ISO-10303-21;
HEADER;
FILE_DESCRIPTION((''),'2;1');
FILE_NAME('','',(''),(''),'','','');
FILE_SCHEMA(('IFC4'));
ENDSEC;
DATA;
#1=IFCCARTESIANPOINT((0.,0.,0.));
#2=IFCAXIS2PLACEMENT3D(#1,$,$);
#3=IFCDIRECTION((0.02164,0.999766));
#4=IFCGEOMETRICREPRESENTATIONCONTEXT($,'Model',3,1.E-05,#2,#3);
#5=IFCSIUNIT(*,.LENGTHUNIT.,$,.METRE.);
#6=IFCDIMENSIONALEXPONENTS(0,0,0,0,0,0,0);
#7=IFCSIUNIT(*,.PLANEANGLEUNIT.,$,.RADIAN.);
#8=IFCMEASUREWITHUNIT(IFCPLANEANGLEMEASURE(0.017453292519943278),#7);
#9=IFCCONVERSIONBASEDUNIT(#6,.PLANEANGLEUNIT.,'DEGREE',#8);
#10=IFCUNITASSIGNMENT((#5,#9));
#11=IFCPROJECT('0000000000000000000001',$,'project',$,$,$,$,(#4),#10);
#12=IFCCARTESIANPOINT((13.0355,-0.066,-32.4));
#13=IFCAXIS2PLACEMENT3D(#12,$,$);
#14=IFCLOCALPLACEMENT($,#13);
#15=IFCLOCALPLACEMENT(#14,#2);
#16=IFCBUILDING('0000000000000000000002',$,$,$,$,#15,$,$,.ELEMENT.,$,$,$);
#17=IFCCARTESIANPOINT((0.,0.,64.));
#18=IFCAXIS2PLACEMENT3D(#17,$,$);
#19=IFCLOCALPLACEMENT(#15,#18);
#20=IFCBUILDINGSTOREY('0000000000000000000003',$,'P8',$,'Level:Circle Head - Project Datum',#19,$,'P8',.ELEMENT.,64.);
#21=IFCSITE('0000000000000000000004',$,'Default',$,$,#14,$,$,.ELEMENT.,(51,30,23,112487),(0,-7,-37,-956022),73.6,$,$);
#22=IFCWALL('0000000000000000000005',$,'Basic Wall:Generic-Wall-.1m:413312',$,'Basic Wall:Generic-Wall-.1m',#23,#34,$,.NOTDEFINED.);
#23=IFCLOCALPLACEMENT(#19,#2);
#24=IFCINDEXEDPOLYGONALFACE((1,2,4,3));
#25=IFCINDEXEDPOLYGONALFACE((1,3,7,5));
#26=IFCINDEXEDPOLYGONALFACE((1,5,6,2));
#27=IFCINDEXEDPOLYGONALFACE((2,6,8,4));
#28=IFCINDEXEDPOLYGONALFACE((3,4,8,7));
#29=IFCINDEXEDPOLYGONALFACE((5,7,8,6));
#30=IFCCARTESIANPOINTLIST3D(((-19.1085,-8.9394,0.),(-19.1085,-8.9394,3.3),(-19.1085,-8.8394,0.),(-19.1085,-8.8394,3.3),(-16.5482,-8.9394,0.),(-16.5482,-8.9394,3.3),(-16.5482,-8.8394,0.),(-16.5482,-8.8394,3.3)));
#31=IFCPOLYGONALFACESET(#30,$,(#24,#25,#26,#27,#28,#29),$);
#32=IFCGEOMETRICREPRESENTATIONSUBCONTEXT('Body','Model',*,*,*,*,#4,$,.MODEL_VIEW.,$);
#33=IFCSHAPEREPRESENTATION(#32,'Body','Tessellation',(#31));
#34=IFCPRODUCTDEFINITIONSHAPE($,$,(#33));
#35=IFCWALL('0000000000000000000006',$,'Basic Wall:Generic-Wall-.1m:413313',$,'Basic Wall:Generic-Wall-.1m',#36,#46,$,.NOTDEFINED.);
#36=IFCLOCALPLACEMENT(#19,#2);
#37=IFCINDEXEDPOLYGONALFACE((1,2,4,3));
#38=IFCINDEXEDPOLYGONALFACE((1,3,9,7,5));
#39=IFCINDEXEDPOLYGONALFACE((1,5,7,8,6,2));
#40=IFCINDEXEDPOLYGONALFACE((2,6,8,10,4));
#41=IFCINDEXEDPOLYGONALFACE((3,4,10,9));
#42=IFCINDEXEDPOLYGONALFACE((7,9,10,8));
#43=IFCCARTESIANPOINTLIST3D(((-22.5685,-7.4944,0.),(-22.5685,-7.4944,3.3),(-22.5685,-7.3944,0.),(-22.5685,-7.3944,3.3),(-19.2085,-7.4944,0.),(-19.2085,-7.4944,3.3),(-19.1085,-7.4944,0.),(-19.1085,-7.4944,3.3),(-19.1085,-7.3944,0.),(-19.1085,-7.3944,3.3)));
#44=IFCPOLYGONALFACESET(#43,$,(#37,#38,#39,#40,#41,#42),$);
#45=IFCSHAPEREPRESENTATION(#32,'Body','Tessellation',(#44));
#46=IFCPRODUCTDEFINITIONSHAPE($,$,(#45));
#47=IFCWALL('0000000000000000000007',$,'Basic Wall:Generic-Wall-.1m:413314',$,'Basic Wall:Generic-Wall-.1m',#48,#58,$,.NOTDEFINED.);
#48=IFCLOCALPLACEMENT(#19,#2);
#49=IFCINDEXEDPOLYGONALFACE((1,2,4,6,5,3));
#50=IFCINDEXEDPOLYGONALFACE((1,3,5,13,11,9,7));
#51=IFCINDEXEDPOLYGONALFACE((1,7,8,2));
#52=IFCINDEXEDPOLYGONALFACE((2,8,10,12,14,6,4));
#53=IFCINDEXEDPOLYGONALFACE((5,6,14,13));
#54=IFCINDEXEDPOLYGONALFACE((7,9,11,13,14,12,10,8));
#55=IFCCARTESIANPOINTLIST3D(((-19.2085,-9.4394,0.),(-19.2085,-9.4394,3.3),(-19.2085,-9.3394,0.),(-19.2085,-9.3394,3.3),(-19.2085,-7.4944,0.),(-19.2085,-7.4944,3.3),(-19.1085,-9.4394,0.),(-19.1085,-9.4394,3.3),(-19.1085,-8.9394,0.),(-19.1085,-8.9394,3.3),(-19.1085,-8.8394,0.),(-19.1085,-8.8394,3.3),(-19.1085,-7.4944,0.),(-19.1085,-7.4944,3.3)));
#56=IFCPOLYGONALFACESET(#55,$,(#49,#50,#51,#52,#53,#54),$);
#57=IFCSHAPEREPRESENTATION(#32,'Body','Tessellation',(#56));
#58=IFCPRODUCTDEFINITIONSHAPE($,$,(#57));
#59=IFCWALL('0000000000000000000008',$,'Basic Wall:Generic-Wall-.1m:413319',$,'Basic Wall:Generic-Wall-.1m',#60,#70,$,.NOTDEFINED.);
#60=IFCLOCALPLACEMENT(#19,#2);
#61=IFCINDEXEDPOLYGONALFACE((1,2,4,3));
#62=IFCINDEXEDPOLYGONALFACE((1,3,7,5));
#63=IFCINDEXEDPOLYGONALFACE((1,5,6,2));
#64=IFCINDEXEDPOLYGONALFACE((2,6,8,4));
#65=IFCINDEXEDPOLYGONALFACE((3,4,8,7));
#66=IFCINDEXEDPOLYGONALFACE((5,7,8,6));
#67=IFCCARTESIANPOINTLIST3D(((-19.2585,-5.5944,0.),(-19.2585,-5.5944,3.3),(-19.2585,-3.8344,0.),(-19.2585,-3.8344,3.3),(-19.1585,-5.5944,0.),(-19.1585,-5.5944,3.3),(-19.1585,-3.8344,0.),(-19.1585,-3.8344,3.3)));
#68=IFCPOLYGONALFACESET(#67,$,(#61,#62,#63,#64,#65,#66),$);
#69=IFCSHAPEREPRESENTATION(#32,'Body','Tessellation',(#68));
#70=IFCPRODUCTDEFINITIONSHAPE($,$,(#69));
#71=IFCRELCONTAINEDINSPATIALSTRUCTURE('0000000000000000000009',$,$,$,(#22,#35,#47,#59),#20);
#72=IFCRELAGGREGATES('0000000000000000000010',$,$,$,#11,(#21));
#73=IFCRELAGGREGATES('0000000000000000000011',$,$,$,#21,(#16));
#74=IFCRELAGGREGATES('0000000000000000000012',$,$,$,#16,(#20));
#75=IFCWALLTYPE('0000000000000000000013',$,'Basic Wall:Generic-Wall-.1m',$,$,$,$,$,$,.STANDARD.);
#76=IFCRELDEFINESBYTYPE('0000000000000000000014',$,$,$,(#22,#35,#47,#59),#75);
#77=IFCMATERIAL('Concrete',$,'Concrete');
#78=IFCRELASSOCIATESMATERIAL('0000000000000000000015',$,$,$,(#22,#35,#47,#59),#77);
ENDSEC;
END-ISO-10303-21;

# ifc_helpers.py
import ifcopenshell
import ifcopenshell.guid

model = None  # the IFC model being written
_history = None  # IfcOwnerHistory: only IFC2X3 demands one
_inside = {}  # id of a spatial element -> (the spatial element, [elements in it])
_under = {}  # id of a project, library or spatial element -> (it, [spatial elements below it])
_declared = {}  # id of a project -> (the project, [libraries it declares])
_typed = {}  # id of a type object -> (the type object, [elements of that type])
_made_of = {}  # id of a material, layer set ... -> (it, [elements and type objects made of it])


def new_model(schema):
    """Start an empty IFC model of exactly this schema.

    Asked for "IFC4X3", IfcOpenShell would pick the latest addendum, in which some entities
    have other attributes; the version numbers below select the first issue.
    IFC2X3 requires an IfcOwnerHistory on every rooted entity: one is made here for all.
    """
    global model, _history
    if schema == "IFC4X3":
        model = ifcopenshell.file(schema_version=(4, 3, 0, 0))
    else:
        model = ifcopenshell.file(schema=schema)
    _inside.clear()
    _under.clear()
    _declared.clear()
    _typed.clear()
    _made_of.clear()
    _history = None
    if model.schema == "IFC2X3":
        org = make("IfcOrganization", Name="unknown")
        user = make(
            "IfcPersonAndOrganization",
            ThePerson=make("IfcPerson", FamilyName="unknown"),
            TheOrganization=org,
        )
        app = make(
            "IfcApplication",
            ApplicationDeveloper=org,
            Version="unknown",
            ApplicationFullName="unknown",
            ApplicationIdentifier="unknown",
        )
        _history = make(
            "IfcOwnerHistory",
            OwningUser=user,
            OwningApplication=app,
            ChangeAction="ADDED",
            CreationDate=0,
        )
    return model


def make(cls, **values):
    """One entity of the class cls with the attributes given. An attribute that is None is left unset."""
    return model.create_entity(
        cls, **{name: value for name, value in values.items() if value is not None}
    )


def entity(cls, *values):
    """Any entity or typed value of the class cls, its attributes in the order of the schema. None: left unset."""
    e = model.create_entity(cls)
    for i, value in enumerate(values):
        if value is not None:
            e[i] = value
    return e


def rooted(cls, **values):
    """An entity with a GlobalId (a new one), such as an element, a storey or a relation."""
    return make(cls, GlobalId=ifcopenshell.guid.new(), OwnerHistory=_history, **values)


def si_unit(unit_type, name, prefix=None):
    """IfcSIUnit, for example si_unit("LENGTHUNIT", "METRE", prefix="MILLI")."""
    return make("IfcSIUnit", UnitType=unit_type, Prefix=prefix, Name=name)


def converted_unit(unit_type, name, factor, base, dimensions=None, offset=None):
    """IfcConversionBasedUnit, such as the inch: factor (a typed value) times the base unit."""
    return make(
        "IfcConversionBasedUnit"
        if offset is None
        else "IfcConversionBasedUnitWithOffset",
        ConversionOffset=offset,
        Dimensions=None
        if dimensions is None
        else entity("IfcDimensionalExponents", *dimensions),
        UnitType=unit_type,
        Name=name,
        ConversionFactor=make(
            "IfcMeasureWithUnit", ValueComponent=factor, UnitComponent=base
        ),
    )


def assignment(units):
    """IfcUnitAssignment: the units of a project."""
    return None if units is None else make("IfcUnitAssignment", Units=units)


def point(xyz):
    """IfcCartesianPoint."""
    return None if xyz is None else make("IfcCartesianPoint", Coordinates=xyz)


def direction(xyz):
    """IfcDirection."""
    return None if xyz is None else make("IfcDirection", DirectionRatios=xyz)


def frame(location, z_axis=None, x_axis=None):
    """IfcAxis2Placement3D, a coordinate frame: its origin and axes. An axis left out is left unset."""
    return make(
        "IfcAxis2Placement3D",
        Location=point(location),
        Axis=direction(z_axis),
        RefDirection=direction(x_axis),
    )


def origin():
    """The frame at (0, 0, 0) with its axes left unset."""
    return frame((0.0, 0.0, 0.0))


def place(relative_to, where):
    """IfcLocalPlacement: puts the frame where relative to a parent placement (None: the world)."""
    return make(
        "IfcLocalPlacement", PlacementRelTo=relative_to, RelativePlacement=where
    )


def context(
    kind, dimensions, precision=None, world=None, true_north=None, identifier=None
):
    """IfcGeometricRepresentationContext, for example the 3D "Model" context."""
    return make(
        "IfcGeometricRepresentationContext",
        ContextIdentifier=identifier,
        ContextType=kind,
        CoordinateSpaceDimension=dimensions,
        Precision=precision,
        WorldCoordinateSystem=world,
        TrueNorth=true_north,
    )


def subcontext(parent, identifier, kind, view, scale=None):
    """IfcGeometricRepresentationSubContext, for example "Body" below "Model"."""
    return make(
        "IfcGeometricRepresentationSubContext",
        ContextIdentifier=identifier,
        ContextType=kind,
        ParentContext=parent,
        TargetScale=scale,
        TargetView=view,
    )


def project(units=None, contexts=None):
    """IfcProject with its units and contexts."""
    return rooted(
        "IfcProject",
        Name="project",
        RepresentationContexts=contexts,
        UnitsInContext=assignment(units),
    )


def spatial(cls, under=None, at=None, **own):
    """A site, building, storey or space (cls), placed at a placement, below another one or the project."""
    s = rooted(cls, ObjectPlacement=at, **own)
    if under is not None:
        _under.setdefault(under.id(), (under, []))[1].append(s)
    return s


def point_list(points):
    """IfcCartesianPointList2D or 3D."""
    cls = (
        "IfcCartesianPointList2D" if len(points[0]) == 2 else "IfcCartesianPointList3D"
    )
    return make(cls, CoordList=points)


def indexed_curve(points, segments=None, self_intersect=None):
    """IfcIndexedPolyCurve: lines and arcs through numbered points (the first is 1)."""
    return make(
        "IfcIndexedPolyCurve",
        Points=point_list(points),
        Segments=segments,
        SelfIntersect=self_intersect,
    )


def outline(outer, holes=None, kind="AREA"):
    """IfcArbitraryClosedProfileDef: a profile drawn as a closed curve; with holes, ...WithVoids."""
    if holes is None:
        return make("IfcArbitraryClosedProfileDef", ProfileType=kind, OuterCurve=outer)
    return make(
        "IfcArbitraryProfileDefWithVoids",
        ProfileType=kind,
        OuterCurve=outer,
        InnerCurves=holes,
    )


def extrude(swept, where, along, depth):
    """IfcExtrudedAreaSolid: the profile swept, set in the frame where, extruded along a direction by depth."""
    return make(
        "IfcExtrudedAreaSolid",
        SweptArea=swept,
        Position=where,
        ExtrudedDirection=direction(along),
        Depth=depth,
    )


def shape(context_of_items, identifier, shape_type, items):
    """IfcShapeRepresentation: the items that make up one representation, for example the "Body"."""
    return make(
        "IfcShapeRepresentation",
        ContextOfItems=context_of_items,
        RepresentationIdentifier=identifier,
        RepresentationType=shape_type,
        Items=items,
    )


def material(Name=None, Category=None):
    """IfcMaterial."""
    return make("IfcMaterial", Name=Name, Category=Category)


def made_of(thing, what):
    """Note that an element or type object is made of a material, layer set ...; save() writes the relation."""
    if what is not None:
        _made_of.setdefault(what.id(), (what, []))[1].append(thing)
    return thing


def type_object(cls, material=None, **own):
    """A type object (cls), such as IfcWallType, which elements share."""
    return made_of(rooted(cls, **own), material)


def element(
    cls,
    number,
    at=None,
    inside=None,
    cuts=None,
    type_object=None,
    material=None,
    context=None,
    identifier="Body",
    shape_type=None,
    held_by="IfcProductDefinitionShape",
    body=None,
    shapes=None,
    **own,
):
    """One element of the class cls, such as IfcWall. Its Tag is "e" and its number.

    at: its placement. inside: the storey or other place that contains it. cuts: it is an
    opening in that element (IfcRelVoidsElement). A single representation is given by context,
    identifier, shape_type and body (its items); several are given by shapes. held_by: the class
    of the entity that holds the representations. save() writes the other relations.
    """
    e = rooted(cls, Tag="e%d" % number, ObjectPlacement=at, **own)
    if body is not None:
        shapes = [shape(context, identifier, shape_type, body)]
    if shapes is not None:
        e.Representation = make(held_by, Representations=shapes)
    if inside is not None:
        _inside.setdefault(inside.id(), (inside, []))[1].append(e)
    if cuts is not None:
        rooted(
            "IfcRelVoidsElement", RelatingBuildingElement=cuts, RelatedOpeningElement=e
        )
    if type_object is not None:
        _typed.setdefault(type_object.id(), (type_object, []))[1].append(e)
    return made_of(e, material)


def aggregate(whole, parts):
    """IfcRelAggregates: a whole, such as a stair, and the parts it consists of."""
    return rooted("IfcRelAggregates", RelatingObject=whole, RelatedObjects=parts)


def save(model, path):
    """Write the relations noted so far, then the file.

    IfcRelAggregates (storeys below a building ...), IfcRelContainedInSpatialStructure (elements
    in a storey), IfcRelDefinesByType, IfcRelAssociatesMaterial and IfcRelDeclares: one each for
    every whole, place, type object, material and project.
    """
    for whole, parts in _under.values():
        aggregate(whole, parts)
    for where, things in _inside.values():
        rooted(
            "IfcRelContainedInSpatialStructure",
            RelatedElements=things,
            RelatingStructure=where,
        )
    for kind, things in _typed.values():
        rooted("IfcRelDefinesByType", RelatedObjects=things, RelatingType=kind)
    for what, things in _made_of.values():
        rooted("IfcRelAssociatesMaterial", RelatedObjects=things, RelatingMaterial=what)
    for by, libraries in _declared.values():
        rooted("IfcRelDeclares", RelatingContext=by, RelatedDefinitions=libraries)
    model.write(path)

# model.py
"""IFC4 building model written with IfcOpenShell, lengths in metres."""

from ifc_helpers import new_model, entity, si_unit, converted_unit, direction, frame, origin, place, context, subcontext, project, spatial, indexed_curve, outline, extrude, material, type_object, element, save


model = new_model("IFC4")

# Units and contexts
model_context = context("Model", 3, precision=1e-05, world=origin(), true_north=direction((0.02164, 0.999766)))
body_context = subcontext(model_context, "Body", "Model", "MODEL_VIEW")
ifc_project = project(units=[si_unit("LENGTHUNIT", "METRE"), converted_unit("PLANEANGLEUNIT", "DEGREE", entity("IfcPlaneAngleMeasure", 0.017453292519943278), si_unit("PLANEANGLEUNIT", "RADIAN"), dimensions=[0, 0, 0, 0, 0, 0, 0])], contexts=[model_context])

# Site, building, storey
site_placement = place(None, frame((13.0355, -0.066, -32.4)))
site = spatial("IfcSite", under=ifc_project, at=site_placement, Name="Default", CompositionType="ELEMENT", RefLatitude=(51, 30, 23, 112487), RefLongitude=(0, -7, -37, -956022), RefElevation=73.6)
building_placement = place(site_placement, origin())
building = spatial("IfcBuilding", under=site, at=building_placement, CompositionType="ELEMENT")
storey_placement = place(building_placement, frame((0.0, 0.0, 64.0)))
storey = spatial("IfcBuildingStorey", under=building, at=storey_placement, Name="P8", ObjectType="Level:Circle Head - Project Datum", LongName="P8", CompositionType="ELEMENT", Elevation=64.0)

# Shared definitions
ifc_material = material(Name="Concrete", Category="Concrete")

# Walls
wall_type = type_object("IfcWallType", Name="Basic Wall:Generic-Wall-.1m", PredefinedType="STANDARD")
wall_1_placement = place(storey_placement, frame((-19.1085, -8.8894, 0.0)))
element("IfcWall", 1, at=wall_1_placement, inside=storey, type_object=wall_type, material=ifc_material, Name="Basic Wall:Generic-Wall-.1m:413312", ObjectType="Basic Wall:Generic-Wall-.1m", PredefinedType="NOTDEFINED", context=body_context, shape_type="SweptSolid", body=[
    extrude(outline(indexed_curve([(2.5602, -0.05), (2.5602, 0.05), (0.0, 0.05), (0.0, -0.05), (2.5602, -0.05)], self_intersect=False)), origin(), (0.0, 0.0, 1.0), 3.3),
])
wall_2_placement = place(storey_placement, frame((-22.5685, -7.4444, 0.0)))
element("IfcWall", 2, at=wall_2_placement, inside=storey, type_object=wall_type, material=ifc_material, Name="Basic Wall:Generic-Wall-.1m:413313", ObjectType="Basic Wall:Generic-Wall-.1m", PredefinedType="NOTDEFINED", context=body_context, shape_type="SweptSolid", body=[
    extrude(outline(indexed_curve([(3.46, -0.05), (3.46, 0.05), (0.0, 0.05), (0.0, -0.05), (3.36, -0.05), (3.46, -0.05)], self_intersect=False)), origin(), (0.0, 0.0, 1.0), 3.3),
])
wall_3_placement = place(storey_placement, frame((-19.1585, -7.4944, 0.0), z_axis=(0.0, 0.0, 1.0), x_axis=(0.0, -1.0, 0.0)))
element("IfcWall", 3, at=wall_3_placement, inside=storey, type_object=wall_type, material=ifc_material, Name="Basic Wall:Generic-Wall-.1m:413314", ObjectType="Basic Wall:Generic-Wall-.1m", PredefinedType="NOTDEFINED", context=body_context, shape_type="SweptSolid", body=[
    extrude(outline(indexed_curve([(1.945, -0.05), (1.945, 0.05), (1.445, 0.05), (1.345, 0.05), (0.0, 0.05), (0.0, -0.05), (1.845, -0.05), (1.945, -0.05)], self_intersect=False)), origin(), (0.0, 0.0, 1.0), 3.3),
])
wall_4_placement = place(storey_placement, frame((-19.2085, -5.5944, 0.0), z_axis=(0.0, 0.0, 1.0), x_axis=(0.0, 1.0, 0.0)))
element("IfcWall", 4, at=wall_4_placement, inside=storey, type_object=wall_type, material=ifc_material, Name="Basic Wall:Generic-Wall-.1m:413319", ObjectType="Basic Wall:Generic-Wall-.1m", PredefinedType="NOTDEFINED", context=body_context, shape_type="SweptSolid", body=[
    extrude(outline(indexed_curve([(1.76, -0.05), (1.76, 0.05), (0.0, 0.05), (0.0, -0.05), (1.76, -0.05)], self_intersect=False)), origin(), (0.0, 0.0, 1.0), 3.3),
])

save(model, "model.ifc")
